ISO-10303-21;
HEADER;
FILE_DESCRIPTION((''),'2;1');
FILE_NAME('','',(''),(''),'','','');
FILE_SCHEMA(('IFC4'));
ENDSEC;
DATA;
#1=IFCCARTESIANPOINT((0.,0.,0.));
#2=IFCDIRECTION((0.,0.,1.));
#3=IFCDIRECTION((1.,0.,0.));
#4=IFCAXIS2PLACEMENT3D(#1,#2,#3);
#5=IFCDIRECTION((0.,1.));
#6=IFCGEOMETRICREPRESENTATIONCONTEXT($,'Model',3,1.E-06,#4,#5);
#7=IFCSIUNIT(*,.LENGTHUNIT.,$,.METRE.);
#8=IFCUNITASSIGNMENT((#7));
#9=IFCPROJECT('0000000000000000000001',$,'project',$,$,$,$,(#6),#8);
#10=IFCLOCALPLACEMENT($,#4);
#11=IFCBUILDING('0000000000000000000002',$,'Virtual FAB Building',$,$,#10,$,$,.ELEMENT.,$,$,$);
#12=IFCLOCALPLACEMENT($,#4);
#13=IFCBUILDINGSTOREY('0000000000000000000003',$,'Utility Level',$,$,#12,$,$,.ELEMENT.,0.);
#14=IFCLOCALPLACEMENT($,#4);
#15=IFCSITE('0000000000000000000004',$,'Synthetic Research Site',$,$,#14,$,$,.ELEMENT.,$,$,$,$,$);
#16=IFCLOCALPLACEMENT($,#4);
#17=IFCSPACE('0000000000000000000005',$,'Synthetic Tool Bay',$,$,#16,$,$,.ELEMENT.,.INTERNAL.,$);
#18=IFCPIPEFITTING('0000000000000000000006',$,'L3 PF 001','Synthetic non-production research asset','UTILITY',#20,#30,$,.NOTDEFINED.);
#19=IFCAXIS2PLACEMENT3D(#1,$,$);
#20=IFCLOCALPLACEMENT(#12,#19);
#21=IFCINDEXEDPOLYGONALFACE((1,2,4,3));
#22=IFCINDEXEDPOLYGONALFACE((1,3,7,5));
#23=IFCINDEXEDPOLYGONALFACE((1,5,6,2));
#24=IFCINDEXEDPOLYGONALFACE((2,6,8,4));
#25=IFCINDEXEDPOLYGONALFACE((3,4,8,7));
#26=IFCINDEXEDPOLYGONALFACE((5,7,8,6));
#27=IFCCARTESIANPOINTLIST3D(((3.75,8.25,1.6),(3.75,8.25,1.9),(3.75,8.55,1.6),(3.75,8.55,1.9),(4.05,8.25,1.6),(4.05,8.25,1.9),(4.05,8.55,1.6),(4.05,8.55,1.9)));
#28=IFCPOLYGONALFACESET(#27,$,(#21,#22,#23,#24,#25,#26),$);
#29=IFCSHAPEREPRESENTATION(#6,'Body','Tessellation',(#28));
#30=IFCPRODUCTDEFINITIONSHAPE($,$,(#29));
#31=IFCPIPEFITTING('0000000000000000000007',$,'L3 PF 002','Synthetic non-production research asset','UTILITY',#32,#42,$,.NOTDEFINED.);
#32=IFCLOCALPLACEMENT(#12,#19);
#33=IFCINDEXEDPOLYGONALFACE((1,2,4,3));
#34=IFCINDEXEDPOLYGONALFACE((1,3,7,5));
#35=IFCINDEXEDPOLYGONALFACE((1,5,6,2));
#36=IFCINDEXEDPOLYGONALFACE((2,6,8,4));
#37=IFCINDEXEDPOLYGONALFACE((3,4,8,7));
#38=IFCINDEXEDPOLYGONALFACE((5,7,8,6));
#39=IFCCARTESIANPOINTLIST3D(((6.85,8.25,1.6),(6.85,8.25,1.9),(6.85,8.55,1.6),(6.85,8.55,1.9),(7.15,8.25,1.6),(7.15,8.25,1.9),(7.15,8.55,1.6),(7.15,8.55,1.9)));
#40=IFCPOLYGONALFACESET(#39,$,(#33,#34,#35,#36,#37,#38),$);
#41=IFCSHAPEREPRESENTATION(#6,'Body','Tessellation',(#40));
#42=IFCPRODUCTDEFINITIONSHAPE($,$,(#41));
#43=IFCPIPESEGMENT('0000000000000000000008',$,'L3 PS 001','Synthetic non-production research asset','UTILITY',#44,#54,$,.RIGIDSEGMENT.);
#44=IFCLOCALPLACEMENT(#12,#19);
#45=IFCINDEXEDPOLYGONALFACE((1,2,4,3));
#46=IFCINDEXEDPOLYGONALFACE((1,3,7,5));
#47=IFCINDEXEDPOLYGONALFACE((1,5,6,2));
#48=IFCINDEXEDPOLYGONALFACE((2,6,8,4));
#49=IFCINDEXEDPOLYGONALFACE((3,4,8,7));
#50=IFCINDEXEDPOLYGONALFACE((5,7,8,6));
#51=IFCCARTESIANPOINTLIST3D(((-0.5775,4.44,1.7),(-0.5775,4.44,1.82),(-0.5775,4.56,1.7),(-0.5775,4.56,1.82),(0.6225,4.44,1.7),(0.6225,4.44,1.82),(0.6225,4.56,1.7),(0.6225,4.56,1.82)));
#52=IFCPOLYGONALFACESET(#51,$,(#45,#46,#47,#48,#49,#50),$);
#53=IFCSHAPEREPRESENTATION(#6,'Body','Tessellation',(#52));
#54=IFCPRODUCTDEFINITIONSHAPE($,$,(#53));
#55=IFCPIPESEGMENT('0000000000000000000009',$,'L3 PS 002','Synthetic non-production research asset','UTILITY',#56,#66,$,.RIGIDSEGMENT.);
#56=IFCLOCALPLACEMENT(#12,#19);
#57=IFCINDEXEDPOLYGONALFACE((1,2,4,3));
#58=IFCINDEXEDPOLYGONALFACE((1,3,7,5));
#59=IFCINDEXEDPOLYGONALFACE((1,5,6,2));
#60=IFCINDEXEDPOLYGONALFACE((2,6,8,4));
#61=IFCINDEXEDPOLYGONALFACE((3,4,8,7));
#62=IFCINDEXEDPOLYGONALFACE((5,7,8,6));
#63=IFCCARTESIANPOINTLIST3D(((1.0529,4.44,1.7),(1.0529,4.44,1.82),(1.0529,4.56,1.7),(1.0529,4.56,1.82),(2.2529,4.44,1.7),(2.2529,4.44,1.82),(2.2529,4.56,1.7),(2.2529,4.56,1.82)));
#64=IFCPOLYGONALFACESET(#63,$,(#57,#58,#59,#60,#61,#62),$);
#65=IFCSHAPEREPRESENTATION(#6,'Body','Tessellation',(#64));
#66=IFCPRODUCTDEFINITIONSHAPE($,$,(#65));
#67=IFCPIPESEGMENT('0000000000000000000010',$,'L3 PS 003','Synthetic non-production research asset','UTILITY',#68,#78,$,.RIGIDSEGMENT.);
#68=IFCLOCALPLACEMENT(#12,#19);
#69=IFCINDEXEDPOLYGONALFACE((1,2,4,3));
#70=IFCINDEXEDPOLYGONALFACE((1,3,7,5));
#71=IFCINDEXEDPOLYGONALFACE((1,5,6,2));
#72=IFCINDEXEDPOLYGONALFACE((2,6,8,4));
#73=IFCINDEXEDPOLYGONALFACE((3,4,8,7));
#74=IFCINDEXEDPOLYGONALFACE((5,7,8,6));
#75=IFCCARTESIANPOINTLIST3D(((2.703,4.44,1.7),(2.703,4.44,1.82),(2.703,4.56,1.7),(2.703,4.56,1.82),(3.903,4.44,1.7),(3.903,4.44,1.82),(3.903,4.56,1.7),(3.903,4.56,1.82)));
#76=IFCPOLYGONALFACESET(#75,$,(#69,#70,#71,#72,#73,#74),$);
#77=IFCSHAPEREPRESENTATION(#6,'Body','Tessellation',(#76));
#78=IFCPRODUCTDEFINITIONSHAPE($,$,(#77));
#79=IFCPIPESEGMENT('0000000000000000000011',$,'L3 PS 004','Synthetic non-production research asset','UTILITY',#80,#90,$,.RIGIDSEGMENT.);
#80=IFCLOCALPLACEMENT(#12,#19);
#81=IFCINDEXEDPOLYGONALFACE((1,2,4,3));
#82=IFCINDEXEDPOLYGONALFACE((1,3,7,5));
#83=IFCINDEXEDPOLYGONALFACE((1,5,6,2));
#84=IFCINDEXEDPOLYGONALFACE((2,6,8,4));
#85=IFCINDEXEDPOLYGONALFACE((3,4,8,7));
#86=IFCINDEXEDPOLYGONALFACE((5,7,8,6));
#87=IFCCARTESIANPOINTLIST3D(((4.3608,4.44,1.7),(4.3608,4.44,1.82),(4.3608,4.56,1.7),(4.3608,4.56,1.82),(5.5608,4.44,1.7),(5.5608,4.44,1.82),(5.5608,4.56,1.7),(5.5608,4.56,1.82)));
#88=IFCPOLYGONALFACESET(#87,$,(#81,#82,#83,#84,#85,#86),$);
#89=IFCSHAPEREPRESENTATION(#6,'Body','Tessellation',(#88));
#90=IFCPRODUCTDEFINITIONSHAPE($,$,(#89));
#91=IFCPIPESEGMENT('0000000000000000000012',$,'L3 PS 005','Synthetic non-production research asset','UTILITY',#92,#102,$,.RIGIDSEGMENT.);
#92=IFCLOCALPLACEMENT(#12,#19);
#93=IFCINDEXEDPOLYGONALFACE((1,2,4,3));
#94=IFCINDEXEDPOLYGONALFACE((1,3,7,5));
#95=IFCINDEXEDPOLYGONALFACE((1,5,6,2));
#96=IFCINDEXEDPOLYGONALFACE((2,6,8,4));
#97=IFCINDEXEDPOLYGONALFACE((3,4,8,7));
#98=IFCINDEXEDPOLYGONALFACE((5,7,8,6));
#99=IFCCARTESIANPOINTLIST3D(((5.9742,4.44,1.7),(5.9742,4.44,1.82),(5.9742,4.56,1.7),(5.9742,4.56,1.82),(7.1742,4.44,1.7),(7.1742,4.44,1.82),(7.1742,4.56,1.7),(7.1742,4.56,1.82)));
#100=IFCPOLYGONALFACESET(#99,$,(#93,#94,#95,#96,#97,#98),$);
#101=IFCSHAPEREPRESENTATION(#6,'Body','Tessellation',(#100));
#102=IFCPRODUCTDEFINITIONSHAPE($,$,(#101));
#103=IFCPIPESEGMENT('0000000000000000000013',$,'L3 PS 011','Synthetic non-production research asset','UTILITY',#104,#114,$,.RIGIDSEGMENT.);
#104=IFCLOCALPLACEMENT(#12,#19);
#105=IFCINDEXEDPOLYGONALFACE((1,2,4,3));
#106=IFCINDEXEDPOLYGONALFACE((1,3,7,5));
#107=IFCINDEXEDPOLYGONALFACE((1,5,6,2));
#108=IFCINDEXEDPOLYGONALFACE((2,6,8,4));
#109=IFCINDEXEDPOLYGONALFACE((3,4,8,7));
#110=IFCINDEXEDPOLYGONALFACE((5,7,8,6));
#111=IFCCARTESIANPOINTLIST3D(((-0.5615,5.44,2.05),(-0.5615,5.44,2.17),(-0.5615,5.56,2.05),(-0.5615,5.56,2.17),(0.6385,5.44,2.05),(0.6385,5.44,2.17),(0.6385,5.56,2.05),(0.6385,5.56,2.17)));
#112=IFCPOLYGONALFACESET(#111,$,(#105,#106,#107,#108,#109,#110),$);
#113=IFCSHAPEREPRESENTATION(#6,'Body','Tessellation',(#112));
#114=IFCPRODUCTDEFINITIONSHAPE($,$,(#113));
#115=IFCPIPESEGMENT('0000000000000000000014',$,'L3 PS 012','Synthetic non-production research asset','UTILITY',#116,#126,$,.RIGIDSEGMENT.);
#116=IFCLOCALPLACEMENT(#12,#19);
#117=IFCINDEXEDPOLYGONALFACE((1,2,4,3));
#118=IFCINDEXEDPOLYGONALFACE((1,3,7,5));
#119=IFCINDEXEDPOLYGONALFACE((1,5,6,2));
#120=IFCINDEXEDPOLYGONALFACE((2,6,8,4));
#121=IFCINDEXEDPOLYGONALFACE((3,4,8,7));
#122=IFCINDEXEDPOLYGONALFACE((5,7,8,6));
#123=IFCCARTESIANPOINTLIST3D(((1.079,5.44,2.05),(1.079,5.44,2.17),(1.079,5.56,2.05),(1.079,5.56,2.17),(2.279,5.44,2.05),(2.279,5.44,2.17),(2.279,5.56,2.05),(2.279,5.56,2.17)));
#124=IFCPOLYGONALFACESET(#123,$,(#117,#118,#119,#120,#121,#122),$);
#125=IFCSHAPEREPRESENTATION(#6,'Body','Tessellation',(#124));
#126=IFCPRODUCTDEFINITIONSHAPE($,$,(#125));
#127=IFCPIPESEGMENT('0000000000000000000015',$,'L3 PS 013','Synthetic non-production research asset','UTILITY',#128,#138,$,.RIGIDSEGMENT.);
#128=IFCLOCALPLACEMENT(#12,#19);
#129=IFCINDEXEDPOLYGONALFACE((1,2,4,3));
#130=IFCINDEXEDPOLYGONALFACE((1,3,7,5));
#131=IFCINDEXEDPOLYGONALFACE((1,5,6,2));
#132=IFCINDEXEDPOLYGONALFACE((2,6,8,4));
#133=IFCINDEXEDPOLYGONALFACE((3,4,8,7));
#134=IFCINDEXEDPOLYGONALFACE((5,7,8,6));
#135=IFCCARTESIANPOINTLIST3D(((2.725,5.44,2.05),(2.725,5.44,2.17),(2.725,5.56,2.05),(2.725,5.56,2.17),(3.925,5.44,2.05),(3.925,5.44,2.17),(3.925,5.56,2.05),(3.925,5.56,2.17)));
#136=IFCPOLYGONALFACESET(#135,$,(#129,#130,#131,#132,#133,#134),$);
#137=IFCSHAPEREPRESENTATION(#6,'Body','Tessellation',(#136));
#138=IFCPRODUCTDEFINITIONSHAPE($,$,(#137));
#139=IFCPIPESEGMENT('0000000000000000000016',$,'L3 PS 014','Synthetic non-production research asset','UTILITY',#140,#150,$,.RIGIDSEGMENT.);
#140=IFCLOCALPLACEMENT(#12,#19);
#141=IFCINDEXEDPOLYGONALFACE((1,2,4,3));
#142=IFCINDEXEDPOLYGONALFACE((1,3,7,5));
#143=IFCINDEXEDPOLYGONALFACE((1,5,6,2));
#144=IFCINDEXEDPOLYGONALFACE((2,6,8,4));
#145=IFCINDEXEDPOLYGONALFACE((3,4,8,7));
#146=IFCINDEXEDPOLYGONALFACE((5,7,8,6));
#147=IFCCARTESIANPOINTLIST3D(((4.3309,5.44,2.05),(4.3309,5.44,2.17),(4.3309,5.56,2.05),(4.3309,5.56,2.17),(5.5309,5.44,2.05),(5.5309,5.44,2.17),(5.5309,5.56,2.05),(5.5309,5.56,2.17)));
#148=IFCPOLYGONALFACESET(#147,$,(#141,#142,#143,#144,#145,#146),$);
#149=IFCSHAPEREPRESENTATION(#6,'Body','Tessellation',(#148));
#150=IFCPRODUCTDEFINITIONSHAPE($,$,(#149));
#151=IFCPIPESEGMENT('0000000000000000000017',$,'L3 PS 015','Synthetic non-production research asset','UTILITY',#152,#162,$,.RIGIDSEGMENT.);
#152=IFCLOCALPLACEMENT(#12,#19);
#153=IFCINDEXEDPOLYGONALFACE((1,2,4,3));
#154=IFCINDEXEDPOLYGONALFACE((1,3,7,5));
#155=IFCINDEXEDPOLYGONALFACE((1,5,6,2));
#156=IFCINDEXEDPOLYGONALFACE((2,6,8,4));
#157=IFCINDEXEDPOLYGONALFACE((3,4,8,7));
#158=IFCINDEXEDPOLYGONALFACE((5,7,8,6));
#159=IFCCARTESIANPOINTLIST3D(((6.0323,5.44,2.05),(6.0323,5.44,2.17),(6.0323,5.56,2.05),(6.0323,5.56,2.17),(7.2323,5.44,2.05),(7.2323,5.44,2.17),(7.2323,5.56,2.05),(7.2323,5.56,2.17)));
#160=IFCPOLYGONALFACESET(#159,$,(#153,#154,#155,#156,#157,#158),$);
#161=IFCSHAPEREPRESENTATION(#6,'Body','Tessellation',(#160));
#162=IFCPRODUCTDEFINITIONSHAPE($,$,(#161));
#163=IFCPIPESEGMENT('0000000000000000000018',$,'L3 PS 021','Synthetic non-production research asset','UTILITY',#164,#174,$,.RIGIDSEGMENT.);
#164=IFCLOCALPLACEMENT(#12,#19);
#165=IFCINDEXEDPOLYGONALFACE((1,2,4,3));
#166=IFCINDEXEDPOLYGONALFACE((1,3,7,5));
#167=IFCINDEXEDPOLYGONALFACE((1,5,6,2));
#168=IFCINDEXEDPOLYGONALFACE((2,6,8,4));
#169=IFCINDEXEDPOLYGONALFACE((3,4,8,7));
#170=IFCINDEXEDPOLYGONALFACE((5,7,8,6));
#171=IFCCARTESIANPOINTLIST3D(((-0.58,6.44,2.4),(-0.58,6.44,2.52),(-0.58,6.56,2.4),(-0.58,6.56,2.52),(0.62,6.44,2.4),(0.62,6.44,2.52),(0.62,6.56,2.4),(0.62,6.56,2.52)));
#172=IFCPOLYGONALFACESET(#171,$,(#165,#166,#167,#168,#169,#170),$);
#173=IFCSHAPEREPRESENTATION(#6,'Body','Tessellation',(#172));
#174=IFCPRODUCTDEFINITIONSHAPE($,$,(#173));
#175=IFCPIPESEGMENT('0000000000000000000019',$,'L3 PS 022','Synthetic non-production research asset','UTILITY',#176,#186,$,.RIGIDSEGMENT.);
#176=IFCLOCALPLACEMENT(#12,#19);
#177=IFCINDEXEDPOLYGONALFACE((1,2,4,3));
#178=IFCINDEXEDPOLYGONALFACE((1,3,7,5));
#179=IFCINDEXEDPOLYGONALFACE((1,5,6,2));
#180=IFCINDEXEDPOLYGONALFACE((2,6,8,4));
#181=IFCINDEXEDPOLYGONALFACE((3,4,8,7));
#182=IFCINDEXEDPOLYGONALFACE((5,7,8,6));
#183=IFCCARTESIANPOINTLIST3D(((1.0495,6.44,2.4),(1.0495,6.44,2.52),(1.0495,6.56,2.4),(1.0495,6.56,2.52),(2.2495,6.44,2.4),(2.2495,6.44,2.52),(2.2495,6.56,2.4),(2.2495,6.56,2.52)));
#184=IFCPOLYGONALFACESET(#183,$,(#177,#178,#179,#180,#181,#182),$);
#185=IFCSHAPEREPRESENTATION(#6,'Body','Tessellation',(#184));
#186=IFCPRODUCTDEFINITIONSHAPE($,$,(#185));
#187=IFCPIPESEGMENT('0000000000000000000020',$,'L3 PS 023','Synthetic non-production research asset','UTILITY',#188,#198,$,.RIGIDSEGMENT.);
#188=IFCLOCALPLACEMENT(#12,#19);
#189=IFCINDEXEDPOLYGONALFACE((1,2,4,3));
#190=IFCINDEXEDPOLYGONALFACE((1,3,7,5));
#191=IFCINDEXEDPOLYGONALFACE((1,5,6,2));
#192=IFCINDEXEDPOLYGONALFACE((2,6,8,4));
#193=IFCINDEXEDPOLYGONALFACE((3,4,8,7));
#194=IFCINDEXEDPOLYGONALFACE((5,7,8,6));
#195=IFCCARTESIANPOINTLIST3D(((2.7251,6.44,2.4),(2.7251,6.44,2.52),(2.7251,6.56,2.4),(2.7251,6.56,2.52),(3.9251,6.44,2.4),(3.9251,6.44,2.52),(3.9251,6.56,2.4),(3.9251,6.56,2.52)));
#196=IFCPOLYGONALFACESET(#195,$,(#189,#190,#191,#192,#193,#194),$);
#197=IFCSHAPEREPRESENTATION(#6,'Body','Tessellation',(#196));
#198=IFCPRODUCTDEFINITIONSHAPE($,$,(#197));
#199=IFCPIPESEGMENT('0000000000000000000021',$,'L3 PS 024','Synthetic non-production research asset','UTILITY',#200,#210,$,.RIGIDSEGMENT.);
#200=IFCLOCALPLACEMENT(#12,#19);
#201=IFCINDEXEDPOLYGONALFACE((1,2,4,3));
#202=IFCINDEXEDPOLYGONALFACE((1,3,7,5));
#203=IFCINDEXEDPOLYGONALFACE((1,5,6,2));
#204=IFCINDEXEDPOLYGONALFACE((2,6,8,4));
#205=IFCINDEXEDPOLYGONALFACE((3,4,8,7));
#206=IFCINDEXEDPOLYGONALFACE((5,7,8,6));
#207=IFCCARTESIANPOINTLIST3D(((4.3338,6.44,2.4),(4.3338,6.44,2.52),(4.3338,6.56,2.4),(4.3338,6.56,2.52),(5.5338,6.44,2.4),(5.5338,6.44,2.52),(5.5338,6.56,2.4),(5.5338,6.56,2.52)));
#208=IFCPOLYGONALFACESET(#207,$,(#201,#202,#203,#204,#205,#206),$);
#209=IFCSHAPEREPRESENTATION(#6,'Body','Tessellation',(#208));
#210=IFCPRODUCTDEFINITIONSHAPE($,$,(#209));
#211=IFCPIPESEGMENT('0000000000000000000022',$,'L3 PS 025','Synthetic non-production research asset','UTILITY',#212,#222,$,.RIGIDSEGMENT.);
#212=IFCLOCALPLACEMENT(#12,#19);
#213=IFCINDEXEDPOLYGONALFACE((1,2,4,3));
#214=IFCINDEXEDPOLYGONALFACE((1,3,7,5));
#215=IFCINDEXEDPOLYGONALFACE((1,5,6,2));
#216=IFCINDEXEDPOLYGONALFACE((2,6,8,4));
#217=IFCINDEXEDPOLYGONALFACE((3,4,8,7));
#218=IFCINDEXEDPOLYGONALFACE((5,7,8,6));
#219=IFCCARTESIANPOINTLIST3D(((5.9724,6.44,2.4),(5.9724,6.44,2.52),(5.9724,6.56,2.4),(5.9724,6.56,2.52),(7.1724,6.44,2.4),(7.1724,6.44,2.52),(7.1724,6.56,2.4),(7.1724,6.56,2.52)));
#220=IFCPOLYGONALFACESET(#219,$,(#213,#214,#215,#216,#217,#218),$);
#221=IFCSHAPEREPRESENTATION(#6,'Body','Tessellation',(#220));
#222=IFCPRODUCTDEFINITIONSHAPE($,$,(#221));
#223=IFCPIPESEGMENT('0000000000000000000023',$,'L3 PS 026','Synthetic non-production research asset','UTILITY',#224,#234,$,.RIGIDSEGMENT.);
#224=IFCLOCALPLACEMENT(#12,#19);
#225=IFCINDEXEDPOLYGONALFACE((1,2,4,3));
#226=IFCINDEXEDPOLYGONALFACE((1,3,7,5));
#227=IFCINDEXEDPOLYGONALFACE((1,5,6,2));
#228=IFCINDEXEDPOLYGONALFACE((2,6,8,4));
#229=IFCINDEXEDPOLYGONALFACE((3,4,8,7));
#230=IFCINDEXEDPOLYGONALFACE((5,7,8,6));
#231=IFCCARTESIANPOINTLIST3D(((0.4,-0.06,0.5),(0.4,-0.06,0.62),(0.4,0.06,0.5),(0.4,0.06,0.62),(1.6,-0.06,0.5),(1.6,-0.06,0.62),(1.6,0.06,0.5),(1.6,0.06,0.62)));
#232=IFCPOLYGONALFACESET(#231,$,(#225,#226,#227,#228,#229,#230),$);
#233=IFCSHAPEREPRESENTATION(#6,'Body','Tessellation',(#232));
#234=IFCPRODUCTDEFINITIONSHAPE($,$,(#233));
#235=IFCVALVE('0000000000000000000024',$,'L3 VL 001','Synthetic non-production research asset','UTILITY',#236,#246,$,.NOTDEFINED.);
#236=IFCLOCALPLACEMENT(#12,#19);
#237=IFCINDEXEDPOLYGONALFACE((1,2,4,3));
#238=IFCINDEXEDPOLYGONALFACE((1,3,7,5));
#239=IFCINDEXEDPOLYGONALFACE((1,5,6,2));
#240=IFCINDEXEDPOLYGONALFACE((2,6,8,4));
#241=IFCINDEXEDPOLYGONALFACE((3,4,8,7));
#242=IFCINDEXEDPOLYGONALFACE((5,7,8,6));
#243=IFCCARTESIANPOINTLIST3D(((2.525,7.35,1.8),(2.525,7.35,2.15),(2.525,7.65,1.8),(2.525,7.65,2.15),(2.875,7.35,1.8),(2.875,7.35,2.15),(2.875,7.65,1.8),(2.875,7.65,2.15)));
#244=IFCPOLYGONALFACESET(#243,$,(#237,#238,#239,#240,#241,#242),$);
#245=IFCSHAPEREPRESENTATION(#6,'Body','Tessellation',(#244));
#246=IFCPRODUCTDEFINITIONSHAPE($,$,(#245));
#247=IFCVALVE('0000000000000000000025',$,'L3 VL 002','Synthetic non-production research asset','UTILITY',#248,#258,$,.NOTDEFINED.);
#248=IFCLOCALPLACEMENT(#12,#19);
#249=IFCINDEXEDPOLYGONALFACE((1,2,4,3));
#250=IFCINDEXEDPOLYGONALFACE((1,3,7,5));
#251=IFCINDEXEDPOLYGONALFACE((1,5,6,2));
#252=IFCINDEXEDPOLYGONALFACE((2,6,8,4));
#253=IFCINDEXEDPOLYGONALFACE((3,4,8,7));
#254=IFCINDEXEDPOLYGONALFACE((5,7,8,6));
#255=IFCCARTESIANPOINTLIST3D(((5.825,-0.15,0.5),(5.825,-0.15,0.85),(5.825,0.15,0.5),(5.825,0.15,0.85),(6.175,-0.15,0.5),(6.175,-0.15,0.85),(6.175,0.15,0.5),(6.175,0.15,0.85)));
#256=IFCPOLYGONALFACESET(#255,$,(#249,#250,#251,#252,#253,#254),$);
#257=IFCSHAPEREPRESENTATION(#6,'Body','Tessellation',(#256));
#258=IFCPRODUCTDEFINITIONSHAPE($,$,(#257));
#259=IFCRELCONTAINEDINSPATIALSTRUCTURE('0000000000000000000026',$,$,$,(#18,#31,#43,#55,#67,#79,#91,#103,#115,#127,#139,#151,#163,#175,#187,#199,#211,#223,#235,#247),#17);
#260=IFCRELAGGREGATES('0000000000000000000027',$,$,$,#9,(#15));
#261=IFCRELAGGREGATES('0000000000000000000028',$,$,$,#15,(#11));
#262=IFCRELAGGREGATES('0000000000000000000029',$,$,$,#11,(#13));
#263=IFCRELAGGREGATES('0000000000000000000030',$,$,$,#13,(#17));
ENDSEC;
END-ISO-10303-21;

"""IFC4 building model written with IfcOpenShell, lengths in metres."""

from ifc_helpers import new_model, si_unit, direction, frame, origin_with_axes, origin_2d_with_axis, place, context, project, spatial, rectangle, extrude, element, save


model = new_model("IFC4")

# Units and contexts
model_context = context("Model", 3, precision=1e-06, world=origin_with_axes(), true_north=direction((0.0, 1.0)))
ifc_project = project(units=[si_unit("LENGTHUNIT", "METRE")], contexts=[model_context])

# Site, building, storey, space
site_placement = place(None, origin_with_axes())
site = spatial("IfcSite", under=ifc_project, at=site_placement, Name="Synthetic Research Site", CompositionType="ELEMENT")
building_placement = place(None, origin_with_axes())
building = spatial("IfcBuilding", under=site, at=building_placement, Name="Virtual FAB Building", CompositionType="ELEMENT")
storey_placement = place(None, origin_with_axes())
storey = spatial("IfcBuildingStorey", under=building, at=storey_placement, Name="Utility Level", CompositionType="ELEMENT", Elevation=0.0)
space_placement = place(None, origin_with_axes())
space = spatial("IfcSpace", under=storey, at=space_placement, Name="Synthetic Tool Bay", CompositionType="ELEMENT", PredefinedType="INTERNAL")

# Pipe fittings
for number, where, z_axis, x_axis, name in (
    (1, (3.9, 8.4, 1.6), (0.0, 0.0, 1.0), (1.0, 0.0, 0.0), "L3 PF 001"),
    (2, (7.0, 8.4, 1.6), (0.0, 0.0, 1.0), (1.0, 0.0, 0.0), "L3 PF 002"),
):
    element("IfcPipeFitting", number, at=place(None, frame(where, z_axis=z_axis, x_axis=x_axis)), inside=space, Name=name, Description="Synthetic non-production research asset", ObjectType="UTILITY", PredefinedType="NOTDEFINED", context=model_context, shape_type="SweptSolid", body=[
        extrude(rectangle(XDim=0.3, YDim=0.3, at=origin_2d_with_axis()), origin_with_axes(), (0.0, 0.0, 1.0), 0.3),
    ])

# Pipe segments
for number, where, z_axis, x_axis, name in (
    (3, (0.0225, 4.5, 1.7), (0.0, 0.0, 1.0), (1.0, 0.0, 0.0), "L3 PS 001"),
    (4, (1.6529, 4.5, 1.7), (0.0, 0.0, 1.0), (1.0, 0.0, 0.0), "L3 PS 002"),
    (5, (3.303, 4.5, 1.7), (0.0, 0.0, 1.0), (1.0, 0.0, 0.0), "L3 PS 003"),
    (6, (4.9608, 4.5, 1.7), (0.0, 0.0, 1.0), (1.0, 0.0, 0.0), "L3 PS 004"),
    (7, (6.5742, 4.5, 1.7), (0.0, 0.0, 1.0), (1.0, 0.0, 0.0), "L3 PS 005"),
    (8, (0.0385, 5.5, 2.05), (0.0, 0.0, 1.0), (1.0, 0.0, 0.0), "L3 PS 011"),
    (9, (1.679, 5.5, 2.05), (0.0, 0.0, 1.0), (1.0, 0.0, 0.0), "L3 PS 012"),
    (10, (3.325, 5.5, 2.05), (0.0, 0.0, 1.0), (1.0, 0.0, 0.0), "L3 PS 013"),
    (11, (4.9309, 5.5, 2.05), (0.0, 0.0, 1.0), (1.0, 0.0, 0.0), "L3 PS 014"),
    (12, (6.6323, 5.5, 2.05), (0.0, 0.0, 1.0), (1.0, 0.0, 0.0), "L3 PS 015"),
    (13, (0.02, 6.5, 2.4), (0.0, 0.0, 1.0), (1.0, 0.0, 0.0), "L3 PS 021"),
    (14, (1.6495, 6.5, 2.4), (0.0, 0.0, 1.0), (1.0, 0.0, 0.0), "L3 PS 022"),
    (15, (3.3251, 6.5, 2.4), (0.0, 0.0, 1.0), (1.0, 0.0, 0.0), "L3 PS 023"),
    (16, (4.9338, 6.5, 2.4), (0.0, 0.0, 1.0), (1.0, 0.0, 0.0), "L3 PS 024"),
    (17, (6.5724, 6.5, 2.4), (0.0, 0.0, 1.0), (1.0, 0.0, 0.0), "L3 PS 025"),
    (18, (1.0, 0.0, 0.5), (0.0, 0.0, 1.0), (1.0, 0.0, 0.0), "L3 PS 026"),
):
    element("IfcPipeSegment", number, at=place(None, frame(where, z_axis=z_axis, x_axis=x_axis)), inside=space, Name=name, Description="Synthetic non-production research asset", ObjectType="UTILITY", PredefinedType="RIGIDSEGMENT", context=model_context, shape_type="SweptSolid", body=[
        extrude(rectangle(XDim=1.2, YDim=0.12, at=origin_2d_with_axis()), origin_with_axes(), (0.0, 0.0, 1.0), 0.12),
    ])

# Valves
for number, where, z_axis, x_axis, name in (
    (19, (2.7, 7.5, 1.8), (0.0, 0.0, 1.0), (1.0, 0.0, 0.0), "L3 VL 001"),
    (20, (6.0, 0.0, 0.5), (0.0, 0.0, 1.0), (1.0, 0.0, 0.0), "L3 VL 002"),
):
    element("IfcValve", number, at=place(None, frame(where, z_axis=z_axis, x_axis=x_axis)), inside=space, Name=name, Description="Synthetic non-production research asset", ObjectType="UTILITY", PredefinedType="NOTDEFINED", context=model_context, shape_type="SweptSolid", body=[
        extrude(rectangle(XDim=0.35, YDim=0.3, at=origin_2d_with_axis()), origin_with_axes(), (0.0, 0.0, 1.0), 0.35),
    ])

save(model, "model.ifc")
